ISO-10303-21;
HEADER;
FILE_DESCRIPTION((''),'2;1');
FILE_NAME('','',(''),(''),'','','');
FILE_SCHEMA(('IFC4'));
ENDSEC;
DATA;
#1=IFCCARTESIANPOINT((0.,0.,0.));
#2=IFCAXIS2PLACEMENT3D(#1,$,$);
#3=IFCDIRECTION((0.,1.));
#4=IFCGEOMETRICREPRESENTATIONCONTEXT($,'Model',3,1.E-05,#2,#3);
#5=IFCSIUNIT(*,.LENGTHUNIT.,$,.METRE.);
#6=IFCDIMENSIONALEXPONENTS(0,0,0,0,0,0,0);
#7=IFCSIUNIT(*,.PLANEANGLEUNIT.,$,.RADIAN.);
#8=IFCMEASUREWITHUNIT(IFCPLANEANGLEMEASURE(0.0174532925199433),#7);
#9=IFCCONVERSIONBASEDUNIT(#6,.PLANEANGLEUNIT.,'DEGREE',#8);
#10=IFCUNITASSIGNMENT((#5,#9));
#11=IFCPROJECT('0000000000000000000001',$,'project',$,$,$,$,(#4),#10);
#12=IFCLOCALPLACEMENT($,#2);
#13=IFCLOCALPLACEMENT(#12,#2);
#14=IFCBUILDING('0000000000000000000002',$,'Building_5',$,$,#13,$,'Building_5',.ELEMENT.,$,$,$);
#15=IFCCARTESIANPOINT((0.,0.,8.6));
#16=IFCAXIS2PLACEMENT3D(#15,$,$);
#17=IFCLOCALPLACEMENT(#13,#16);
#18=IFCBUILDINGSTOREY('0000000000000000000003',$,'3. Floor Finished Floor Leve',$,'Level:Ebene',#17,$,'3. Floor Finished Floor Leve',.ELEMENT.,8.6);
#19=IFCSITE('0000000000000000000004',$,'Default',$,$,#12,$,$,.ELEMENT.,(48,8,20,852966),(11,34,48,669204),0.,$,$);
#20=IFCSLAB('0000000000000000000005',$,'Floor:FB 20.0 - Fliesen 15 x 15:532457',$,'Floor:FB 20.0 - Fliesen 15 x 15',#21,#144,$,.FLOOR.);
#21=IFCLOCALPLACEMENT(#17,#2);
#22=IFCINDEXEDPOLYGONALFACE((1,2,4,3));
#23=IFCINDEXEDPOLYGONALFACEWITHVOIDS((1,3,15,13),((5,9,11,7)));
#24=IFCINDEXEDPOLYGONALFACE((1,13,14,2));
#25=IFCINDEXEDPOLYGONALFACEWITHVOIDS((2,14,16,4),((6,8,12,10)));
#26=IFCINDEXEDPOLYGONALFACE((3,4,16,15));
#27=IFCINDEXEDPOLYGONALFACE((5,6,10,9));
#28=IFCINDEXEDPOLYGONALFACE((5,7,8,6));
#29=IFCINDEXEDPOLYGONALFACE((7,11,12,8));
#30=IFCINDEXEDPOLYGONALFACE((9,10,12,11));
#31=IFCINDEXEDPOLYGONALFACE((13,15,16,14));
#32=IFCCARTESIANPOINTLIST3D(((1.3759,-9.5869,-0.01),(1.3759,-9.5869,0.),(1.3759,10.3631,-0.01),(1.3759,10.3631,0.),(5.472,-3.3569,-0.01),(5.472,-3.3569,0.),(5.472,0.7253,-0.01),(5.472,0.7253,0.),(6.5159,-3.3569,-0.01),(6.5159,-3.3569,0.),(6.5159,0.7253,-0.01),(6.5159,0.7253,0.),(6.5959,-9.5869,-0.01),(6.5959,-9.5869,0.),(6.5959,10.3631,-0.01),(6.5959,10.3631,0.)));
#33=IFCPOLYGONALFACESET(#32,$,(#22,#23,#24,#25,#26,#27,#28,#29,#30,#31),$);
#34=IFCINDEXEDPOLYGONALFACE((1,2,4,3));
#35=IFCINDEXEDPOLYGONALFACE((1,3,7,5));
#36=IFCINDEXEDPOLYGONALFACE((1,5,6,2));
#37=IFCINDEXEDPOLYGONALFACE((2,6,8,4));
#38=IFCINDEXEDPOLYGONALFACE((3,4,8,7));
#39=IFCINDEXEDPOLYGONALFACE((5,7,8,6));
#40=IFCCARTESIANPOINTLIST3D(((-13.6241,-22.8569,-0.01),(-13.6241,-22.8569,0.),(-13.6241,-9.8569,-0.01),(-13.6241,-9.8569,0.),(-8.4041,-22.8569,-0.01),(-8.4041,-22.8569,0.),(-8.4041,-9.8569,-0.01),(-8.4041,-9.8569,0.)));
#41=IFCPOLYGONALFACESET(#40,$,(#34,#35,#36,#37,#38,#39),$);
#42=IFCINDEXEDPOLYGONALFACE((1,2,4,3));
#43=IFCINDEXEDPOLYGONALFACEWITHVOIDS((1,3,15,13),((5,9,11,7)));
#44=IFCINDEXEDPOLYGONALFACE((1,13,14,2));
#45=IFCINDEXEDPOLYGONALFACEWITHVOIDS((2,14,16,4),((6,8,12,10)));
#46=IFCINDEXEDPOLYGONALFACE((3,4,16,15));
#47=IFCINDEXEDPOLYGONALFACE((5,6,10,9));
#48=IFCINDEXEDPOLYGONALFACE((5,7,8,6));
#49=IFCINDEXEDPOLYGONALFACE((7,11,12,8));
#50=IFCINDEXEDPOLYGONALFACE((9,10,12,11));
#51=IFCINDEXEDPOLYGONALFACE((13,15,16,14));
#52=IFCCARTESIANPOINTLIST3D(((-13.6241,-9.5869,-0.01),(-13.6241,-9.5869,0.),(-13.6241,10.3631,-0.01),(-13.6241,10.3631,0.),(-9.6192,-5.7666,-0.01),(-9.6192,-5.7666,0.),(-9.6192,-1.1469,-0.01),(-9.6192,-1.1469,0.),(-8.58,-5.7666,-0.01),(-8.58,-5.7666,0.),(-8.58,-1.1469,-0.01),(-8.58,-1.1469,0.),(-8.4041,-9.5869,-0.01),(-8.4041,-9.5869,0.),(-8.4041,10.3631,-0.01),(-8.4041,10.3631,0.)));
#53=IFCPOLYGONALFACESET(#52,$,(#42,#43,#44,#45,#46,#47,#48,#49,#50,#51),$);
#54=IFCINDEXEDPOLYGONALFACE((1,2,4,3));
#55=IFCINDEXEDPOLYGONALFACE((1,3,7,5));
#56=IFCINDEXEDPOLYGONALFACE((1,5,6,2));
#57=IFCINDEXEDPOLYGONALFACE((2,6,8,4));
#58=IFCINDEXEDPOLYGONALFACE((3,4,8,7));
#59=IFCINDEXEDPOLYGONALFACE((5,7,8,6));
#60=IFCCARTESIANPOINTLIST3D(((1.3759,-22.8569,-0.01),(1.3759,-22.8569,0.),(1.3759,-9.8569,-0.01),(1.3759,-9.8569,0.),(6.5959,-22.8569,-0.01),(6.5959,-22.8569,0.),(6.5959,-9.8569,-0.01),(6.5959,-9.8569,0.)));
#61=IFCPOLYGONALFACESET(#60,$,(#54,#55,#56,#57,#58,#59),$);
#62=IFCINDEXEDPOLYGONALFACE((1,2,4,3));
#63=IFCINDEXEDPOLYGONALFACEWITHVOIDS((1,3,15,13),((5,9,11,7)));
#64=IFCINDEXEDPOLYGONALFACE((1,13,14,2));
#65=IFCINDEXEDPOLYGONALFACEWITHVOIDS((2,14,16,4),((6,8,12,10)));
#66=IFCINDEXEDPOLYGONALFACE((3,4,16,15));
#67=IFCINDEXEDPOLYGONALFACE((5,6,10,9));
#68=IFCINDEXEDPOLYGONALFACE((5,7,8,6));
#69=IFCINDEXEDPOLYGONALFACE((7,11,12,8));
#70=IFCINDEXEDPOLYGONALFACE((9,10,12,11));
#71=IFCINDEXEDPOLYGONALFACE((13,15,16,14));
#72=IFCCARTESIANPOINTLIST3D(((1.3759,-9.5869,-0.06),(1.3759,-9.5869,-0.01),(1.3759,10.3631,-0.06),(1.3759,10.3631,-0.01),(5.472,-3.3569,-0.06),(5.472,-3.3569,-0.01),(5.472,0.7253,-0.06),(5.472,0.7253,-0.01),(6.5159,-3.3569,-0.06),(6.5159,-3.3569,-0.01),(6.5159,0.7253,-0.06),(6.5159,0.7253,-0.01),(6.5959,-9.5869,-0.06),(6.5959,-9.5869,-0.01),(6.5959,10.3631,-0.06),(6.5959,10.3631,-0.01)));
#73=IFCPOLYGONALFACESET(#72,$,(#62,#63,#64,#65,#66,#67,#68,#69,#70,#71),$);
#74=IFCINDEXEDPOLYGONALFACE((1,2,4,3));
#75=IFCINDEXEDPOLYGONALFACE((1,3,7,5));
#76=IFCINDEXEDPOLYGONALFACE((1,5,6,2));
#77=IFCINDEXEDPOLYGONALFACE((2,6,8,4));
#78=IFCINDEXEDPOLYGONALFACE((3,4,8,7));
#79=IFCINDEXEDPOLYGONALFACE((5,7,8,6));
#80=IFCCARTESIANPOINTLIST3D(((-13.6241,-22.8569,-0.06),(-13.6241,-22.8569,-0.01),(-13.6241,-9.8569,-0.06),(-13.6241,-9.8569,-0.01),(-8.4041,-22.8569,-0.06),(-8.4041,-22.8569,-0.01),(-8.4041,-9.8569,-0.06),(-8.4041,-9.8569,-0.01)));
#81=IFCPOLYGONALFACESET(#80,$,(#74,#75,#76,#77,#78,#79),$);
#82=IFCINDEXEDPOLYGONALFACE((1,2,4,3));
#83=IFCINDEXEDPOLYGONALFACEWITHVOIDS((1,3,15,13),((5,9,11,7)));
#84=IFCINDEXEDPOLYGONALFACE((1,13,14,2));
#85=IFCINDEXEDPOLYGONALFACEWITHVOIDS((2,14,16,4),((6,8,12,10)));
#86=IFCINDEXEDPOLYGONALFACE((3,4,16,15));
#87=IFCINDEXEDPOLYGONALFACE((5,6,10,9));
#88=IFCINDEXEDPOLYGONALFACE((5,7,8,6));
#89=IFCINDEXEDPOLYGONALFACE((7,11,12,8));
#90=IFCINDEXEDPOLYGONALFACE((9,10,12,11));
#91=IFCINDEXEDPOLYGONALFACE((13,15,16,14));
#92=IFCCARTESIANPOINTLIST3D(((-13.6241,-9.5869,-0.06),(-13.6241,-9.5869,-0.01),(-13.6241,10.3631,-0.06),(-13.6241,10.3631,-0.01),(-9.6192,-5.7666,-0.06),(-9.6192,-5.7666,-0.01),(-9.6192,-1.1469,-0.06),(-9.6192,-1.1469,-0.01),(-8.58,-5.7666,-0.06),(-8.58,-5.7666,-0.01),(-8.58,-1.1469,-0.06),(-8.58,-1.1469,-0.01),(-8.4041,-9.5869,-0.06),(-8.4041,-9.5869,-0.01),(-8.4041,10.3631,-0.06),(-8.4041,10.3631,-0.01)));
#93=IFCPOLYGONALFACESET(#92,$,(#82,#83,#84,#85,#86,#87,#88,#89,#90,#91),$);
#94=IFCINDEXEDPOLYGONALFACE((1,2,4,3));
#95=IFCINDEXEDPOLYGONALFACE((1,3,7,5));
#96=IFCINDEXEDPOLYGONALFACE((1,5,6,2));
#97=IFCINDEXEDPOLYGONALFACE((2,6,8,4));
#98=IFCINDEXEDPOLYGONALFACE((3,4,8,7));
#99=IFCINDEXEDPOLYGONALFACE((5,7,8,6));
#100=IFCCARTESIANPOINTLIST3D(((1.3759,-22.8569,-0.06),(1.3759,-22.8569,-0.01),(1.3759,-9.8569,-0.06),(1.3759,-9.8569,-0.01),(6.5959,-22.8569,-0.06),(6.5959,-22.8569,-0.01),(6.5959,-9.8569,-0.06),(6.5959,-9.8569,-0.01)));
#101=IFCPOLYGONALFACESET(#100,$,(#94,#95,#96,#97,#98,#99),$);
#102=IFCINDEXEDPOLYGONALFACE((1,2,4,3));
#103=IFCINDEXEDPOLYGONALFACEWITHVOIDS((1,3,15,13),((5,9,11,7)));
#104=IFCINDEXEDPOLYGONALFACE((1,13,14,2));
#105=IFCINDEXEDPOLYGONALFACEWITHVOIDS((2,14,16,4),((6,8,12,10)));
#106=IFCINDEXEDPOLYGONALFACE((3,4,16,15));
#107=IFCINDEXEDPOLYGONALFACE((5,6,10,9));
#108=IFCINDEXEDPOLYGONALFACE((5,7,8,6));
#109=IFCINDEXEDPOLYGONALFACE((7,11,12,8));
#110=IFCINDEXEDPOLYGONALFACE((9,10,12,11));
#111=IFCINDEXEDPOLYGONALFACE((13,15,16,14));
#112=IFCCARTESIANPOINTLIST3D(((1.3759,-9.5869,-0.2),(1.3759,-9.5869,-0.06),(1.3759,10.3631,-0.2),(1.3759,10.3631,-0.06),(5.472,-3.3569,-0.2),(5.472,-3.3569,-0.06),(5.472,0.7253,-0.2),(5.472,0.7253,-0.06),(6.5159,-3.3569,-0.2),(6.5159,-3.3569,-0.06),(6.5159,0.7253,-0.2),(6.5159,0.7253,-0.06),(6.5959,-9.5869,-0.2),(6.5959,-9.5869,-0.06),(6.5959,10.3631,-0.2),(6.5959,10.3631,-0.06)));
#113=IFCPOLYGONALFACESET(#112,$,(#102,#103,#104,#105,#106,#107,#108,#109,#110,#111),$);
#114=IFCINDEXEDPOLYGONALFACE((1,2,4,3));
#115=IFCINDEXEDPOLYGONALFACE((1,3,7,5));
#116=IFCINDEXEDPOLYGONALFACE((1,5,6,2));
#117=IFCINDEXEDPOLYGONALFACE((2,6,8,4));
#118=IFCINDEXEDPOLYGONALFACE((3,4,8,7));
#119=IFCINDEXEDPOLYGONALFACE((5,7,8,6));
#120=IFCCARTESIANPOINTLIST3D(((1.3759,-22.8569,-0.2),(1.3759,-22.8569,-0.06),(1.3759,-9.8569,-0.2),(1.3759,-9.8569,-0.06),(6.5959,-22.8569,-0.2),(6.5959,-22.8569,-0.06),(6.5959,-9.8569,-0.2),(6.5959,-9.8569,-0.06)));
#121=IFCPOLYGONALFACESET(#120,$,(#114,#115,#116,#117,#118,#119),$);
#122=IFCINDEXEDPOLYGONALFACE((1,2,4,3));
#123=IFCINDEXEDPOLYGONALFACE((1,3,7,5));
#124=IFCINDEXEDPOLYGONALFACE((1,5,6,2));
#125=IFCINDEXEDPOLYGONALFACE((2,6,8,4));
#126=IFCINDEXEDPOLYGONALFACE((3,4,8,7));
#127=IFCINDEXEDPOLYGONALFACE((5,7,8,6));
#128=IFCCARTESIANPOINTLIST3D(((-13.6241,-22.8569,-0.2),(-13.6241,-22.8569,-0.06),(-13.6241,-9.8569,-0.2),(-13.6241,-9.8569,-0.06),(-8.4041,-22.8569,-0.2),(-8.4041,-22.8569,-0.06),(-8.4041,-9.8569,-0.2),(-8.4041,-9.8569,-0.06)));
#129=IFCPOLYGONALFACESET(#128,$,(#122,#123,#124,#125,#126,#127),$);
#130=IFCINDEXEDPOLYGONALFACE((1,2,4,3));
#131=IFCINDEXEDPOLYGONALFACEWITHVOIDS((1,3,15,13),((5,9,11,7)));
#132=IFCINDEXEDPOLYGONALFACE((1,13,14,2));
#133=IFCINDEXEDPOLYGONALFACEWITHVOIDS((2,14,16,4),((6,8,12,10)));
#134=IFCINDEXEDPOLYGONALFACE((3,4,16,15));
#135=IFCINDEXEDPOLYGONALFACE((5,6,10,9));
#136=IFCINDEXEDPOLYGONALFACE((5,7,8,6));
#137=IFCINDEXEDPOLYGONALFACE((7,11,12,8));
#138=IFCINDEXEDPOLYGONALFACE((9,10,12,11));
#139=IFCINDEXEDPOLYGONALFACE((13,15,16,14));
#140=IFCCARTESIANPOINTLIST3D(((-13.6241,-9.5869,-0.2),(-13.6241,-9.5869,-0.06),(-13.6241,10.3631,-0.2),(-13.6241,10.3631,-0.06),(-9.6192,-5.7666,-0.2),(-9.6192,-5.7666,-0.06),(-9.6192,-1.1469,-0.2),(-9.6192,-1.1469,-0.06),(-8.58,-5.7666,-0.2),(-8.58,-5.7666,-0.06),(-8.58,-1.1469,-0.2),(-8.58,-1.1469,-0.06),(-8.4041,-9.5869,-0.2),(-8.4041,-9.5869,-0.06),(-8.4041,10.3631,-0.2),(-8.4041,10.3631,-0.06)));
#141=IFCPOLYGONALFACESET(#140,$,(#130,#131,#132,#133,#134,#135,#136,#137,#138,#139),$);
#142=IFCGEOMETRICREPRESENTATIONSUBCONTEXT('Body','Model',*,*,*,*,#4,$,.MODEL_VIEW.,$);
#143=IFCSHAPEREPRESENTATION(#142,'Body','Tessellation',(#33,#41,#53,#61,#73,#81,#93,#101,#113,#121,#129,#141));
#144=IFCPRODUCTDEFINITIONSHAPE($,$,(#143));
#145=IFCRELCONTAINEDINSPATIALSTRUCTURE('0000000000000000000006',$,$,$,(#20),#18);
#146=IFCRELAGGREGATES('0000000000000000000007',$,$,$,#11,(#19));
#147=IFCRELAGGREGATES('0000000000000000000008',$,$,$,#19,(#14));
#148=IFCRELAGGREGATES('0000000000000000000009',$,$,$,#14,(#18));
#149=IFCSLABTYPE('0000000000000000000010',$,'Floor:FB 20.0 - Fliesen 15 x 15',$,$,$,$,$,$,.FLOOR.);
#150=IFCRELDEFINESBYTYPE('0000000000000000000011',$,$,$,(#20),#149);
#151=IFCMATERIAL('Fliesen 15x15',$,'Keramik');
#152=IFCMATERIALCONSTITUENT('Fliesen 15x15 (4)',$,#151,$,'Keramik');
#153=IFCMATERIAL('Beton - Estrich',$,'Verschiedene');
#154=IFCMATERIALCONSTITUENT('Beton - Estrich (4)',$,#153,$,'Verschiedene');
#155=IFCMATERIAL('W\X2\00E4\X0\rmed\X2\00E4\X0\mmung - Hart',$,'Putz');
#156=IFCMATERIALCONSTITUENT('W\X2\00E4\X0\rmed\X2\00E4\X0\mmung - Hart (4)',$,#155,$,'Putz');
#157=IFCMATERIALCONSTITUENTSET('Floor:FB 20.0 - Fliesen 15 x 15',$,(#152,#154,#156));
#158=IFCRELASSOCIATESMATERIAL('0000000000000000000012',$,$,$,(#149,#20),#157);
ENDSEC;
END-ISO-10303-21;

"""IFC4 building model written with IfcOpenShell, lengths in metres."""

from ifc_helpers import new_model, entity, si_unit, converted_unit, direction, frame, origin, place, context, subcontext, project, spatial, indexed_curve, outline, extrude, material, constituent, constituent_set, type_object, element, save


model = new_model("IFC4")

# Units and contexts
model_context = context("Model", 3, precision=1e-05, world=origin(), true_north=direction((0.0, 1.0)))
body_context = subcontext(model_context, "Body", "Model", "MODEL_VIEW")
ifc_project = project(units=[si_unit("LENGTHUNIT", "METRE"), converted_unit("PLANEANGLEUNIT", "DEGREE", entity("IfcPlaneAngleMeasure", 0.0174532925199433), si_unit("PLANEANGLEUNIT", "RADIAN"), dimensions=[0, 0, 0, 0, 0, 0, 0])], contexts=[model_context])

# Site, building, storey
site_placement = place(None, origin())
site = spatial("IfcSite", under=ifc_project, at=site_placement, Name="Default", CompositionType="ELEMENT", RefLatitude=(48, 8, 20, 852966), RefLongitude=(11, 34, 48, 669204), RefElevation=0.0)
building_placement = place(site_placement, origin())
building = spatial("IfcBuilding", under=site, at=building_placement, Name="Building_5", LongName="Building_5", CompositionType="ELEMENT")
storey_placement = place(building_placement, frame((0.0, 0.0, 8.6)))
storey = spatial("IfcBuildingStorey", under=building, at=storey_placement, Name="3. Floor Finished Floor Leve", ObjectType="Level:Ebene", LongName="3. Floor Finished Floor Leve", CompositionType="ELEMENT", Elevation=8.6)

# Slab, openings
ifc_material_1 = material(Name="Fliesen 15x15", Category="Keramik")
ifc_constituent_1 = constituent(ifc_material_1, Name="Fliesen 15x15 (4)", Category="Keramik")
ifc_material_2 = material(Name="Beton - Estrich", Category="Verschiedene")
ifc_constituent_2 = constituent(ifc_material_2, Name="Beton - Estrich (4)", Category="Verschiedene")
ifc_material_3 = material(Name="Wärmedämmung - Hart", Category="Putz")
ifc_constituent_3 = constituent(ifc_material_3, Name="Wärmedämmung - Hart (4)", Category="Putz")
ifc_constituent_set_1 = constituent_set(constituents=[ifc_constituent_1, ifc_constituent_2, ifc_constituent_3], Name="Floor:FB 20.0 - Fliesen 15 x 15")
slab_type_1 = type_object("IfcSlabType", Name="Floor:FB 20.0 - Fliesen 15 x 15", PredefinedType="FLOOR", material=ifc_constituent_set_1)
slab_1_placement = place(storey_placement, origin())
slab_1 = element("IfcSlab", 1, at=slab_1_placement, inside=storey, type_object=slab_type_1, material=ifc_constituent_set_1, Name="Floor:FB 20.0 - Fliesen 15 x 15:532457", ObjectType="Floor:FB 20.0 - Fliesen 15 x 15", PredefinedType="FLOOR", context=body_context, shape_type="SweptSolid", body=[
    extrude(outline(indexed_curve([(-2.61, -9.975), (2.61, -9.975), (2.61, 9.975), (-2.61, 9.975), (-2.61, -9.975)], self_intersect=False), holes=[indexed_curve([(-2.53, 3.745), (-1.4861, 3.745), (-1.4861, -0.3372), (-2.53, -0.3372), (-2.53, 3.745)], self_intersect=False)]), frame((3.9859, 0.3881, -0.01), z_axis=(0.0, 0.0, 1.0), x_axis=(-1.0, 0.0, 0.0)), (0.0, 0.0, 1.0), 0.01),
    extrude(outline(indexed_curve([(-2.61, -6.5), (2.61, -6.5), (2.61, 6.5), (-2.61, 6.5), (-2.61, -6.5)], self_intersect=False)), frame((-11.0141, -16.3569, -0.01), z_axis=(0.0, 0.0, 1.0), x_axis=(-1.0, 0.0, 0.0)), (0.0, 0.0, 1.0), 0.01),
    extrude(outline(indexed_curve([(-2.61, -9.975), (2.61, -9.975), (2.61, 9.975), (-2.61, 9.975), (-2.61, -9.975)], self_intersect=False), holes=[indexed_curve([(-2.434, 1.535), (-2.434, 6.1547), (-1.3948, 6.1547), (-1.3948, 1.535), (-2.434, 1.535)], self_intersect=False)]), frame((-11.0141, 0.3881, -0.01), z_axis=(0.0, 0.0, 1.0), x_axis=(-1.0, 0.0, 0.0)), (0.0, 0.0, 1.0), 0.01),
    extrude(outline(indexed_curve([(-2.61, -6.5), (2.61, -6.5), (2.61, 6.5), (-2.61, 6.5), (-2.61, -6.5)], self_intersect=False)), frame((3.9859, -16.3569, -0.01), z_axis=(0.0, 0.0, 1.0), x_axis=(-1.0, 0.0, 0.0)), (0.0, 0.0, 1.0), 0.01),
    extrude(outline(indexed_curve([(-2.61, -9.975), (2.61, -9.975), (2.61, 9.975), (-2.61, 9.975), (-2.61, -9.975)], self_intersect=False), holes=[indexed_curve([(-2.53, 3.745), (-1.4861, 3.745), (-1.4861, -0.3372), (-2.53, -0.3372), (-2.53, 3.745)], self_intersect=False)]), frame((3.9859, 0.3881, -0.06), z_axis=(0.0, 0.0, 1.0), x_axis=(-1.0, 0.0, 0.0)), (0.0, 0.0, 1.0), 0.05),
    extrude(outline(indexed_curve([(-2.61, -6.5), (2.61, -6.5), (2.61, 6.5), (-2.61, 6.5), (-2.61, -6.5)], self_intersect=False)), frame((-11.0141, -16.3569, -0.06), z_axis=(0.0, 0.0, 1.0), x_axis=(-1.0, 0.0, 0.0)), (0.0, 0.0, 1.0), 0.05),
    extrude(outline(indexed_curve([(-2.61, -9.975), (2.61, -9.975), (2.61, 9.975), (-2.61, 9.975), (-2.61, -9.975)], self_intersect=False), holes=[indexed_curve([(-2.434, 1.535), (-2.434, 6.1547), (-1.3948, 6.1547), (-1.3948, 1.535), (-2.434, 1.535)], self_intersect=False)]), frame((-11.0141, 0.3881, -0.06), z_axis=(0.0, 0.0, 1.0), x_axis=(-1.0, 0.0, 0.0)), (0.0, 0.0, 1.0), 0.05),
    extrude(outline(indexed_curve([(-2.61, -6.5), (2.61, -6.5), (2.61, 6.5), (-2.61, 6.5), (-2.61, -6.5)], self_intersect=False)), frame((3.9859, -16.3569, -0.06), z_axis=(0.0, 0.0, 1.0), x_axis=(-1.0, 0.0, 0.0)), (0.0, 0.0, 1.0), 0.05),
    extrude(outline(indexed_curve([(-2.61, -9.975), (2.61, -9.975), (2.61, 9.975), (-2.61, 9.975), (-2.61, -9.975)], self_intersect=False), holes=[indexed_curve([(-2.53, 3.745), (-1.4861, 3.745), (-1.4861, -0.3372), (-2.53, -0.3372), (-2.53, 3.745)], self_intersect=False)]), frame((3.9859, 0.3881, -0.2), z_axis=(0.0, 0.0, 1.0), x_axis=(-1.0, 0.0, 0.0)), (0.0, 0.0, 1.0), 0.14),
    extrude(outline(indexed_curve([(-2.61, -6.5), (2.61, -6.5), (2.61, 6.5), (-2.61, 6.5), (-2.61, -6.5)], self_intersect=False)), frame((3.9859, -16.3569, -0.2), z_axis=(0.0, 0.0, 1.0), x_axis=(-1.0, 0.0, 0.0)), (0.0, 0.0, 1.0), 0.14),
    extrude(outline(indexed_curve([(-2.61, -6.5), (2.61, -6.5), (2.61, 6.5), (-2.61, 6.5), (-2.61, -6.5)], self_intersect=False)), frame((-11.0141, -16.3569, -0.2), z_axis=(0.0, 0.0, 1.0), x_axis=(-1.0, 0.0, 0.0)), (0.0, 0.0, 1.0), 0.14),
    extrude(outline(indexed_curve([(-2.61, -9.975), (2.61, -9.975), (2.61, 9.975), (-2.61, 9.975), (-2.61, -9.975)], self_intersect=False), holes=[indexed_curve([(-2.434, 1.535), (-2.434, 6.1547), (-1.3948, 6.1547), (-1.3948, 1.535), (-2.434, 1.535)], self_intersect=False)]), frame((-11.0141, 0.3881, -0.2), z_axis=(0.0, 0.0, 1.0), x_axis=(-1.0, 0.0, 0.0)), (0.0, 0.0, 1.0), 0.14),
])
opening_1_placement = place(slab_1_placement, origin())
element("IfcOpeningElement", 2, at=opening_1_placement, cuts=slab_1, PredefinedType="OPENING", context=body_context, shape_type="SweptSolid", body=[
    extrude(outline(indexed_curve([(-2.3099, -0.5196), (2.3099, -0.5196), (2.3099, 0.5196), (-2.3099, 0.5196), (-2.3099, -0.5196)], self_intersect=False)), frame((-9.0996, -3.4567, 0.0), z_axis=(0.0, 0.0, -1.0), x_axis=(0.0, -1.0, 0.0)), (0.0, 0.0, 1.0), 0.2),
])
opening_2_placement = place(slab_1_placement, origin())
element("IfcOpeningElement", 3, at=opening_2_placement, cuts=slab_1, PredefinedType="OPENING", context=body_context, shape_type="SweptSolid", body=[
    extrude(outline(indexed_curve([(-0.522, -2.0411), (0.522, -2.0411), (0.522, 2.0411), (-0.522, 2.0411), (-0.522, -2.0411)], self_intersect=False)), frame((5.994, -1.3158, 0.0), z_axis=(0.0, 0.0, -1.0), x_axis=(-1.0, 0.0, 0.0)), (0.0, 0.0, 1.0), 0.2),
])

save(model, "model.ifc")
